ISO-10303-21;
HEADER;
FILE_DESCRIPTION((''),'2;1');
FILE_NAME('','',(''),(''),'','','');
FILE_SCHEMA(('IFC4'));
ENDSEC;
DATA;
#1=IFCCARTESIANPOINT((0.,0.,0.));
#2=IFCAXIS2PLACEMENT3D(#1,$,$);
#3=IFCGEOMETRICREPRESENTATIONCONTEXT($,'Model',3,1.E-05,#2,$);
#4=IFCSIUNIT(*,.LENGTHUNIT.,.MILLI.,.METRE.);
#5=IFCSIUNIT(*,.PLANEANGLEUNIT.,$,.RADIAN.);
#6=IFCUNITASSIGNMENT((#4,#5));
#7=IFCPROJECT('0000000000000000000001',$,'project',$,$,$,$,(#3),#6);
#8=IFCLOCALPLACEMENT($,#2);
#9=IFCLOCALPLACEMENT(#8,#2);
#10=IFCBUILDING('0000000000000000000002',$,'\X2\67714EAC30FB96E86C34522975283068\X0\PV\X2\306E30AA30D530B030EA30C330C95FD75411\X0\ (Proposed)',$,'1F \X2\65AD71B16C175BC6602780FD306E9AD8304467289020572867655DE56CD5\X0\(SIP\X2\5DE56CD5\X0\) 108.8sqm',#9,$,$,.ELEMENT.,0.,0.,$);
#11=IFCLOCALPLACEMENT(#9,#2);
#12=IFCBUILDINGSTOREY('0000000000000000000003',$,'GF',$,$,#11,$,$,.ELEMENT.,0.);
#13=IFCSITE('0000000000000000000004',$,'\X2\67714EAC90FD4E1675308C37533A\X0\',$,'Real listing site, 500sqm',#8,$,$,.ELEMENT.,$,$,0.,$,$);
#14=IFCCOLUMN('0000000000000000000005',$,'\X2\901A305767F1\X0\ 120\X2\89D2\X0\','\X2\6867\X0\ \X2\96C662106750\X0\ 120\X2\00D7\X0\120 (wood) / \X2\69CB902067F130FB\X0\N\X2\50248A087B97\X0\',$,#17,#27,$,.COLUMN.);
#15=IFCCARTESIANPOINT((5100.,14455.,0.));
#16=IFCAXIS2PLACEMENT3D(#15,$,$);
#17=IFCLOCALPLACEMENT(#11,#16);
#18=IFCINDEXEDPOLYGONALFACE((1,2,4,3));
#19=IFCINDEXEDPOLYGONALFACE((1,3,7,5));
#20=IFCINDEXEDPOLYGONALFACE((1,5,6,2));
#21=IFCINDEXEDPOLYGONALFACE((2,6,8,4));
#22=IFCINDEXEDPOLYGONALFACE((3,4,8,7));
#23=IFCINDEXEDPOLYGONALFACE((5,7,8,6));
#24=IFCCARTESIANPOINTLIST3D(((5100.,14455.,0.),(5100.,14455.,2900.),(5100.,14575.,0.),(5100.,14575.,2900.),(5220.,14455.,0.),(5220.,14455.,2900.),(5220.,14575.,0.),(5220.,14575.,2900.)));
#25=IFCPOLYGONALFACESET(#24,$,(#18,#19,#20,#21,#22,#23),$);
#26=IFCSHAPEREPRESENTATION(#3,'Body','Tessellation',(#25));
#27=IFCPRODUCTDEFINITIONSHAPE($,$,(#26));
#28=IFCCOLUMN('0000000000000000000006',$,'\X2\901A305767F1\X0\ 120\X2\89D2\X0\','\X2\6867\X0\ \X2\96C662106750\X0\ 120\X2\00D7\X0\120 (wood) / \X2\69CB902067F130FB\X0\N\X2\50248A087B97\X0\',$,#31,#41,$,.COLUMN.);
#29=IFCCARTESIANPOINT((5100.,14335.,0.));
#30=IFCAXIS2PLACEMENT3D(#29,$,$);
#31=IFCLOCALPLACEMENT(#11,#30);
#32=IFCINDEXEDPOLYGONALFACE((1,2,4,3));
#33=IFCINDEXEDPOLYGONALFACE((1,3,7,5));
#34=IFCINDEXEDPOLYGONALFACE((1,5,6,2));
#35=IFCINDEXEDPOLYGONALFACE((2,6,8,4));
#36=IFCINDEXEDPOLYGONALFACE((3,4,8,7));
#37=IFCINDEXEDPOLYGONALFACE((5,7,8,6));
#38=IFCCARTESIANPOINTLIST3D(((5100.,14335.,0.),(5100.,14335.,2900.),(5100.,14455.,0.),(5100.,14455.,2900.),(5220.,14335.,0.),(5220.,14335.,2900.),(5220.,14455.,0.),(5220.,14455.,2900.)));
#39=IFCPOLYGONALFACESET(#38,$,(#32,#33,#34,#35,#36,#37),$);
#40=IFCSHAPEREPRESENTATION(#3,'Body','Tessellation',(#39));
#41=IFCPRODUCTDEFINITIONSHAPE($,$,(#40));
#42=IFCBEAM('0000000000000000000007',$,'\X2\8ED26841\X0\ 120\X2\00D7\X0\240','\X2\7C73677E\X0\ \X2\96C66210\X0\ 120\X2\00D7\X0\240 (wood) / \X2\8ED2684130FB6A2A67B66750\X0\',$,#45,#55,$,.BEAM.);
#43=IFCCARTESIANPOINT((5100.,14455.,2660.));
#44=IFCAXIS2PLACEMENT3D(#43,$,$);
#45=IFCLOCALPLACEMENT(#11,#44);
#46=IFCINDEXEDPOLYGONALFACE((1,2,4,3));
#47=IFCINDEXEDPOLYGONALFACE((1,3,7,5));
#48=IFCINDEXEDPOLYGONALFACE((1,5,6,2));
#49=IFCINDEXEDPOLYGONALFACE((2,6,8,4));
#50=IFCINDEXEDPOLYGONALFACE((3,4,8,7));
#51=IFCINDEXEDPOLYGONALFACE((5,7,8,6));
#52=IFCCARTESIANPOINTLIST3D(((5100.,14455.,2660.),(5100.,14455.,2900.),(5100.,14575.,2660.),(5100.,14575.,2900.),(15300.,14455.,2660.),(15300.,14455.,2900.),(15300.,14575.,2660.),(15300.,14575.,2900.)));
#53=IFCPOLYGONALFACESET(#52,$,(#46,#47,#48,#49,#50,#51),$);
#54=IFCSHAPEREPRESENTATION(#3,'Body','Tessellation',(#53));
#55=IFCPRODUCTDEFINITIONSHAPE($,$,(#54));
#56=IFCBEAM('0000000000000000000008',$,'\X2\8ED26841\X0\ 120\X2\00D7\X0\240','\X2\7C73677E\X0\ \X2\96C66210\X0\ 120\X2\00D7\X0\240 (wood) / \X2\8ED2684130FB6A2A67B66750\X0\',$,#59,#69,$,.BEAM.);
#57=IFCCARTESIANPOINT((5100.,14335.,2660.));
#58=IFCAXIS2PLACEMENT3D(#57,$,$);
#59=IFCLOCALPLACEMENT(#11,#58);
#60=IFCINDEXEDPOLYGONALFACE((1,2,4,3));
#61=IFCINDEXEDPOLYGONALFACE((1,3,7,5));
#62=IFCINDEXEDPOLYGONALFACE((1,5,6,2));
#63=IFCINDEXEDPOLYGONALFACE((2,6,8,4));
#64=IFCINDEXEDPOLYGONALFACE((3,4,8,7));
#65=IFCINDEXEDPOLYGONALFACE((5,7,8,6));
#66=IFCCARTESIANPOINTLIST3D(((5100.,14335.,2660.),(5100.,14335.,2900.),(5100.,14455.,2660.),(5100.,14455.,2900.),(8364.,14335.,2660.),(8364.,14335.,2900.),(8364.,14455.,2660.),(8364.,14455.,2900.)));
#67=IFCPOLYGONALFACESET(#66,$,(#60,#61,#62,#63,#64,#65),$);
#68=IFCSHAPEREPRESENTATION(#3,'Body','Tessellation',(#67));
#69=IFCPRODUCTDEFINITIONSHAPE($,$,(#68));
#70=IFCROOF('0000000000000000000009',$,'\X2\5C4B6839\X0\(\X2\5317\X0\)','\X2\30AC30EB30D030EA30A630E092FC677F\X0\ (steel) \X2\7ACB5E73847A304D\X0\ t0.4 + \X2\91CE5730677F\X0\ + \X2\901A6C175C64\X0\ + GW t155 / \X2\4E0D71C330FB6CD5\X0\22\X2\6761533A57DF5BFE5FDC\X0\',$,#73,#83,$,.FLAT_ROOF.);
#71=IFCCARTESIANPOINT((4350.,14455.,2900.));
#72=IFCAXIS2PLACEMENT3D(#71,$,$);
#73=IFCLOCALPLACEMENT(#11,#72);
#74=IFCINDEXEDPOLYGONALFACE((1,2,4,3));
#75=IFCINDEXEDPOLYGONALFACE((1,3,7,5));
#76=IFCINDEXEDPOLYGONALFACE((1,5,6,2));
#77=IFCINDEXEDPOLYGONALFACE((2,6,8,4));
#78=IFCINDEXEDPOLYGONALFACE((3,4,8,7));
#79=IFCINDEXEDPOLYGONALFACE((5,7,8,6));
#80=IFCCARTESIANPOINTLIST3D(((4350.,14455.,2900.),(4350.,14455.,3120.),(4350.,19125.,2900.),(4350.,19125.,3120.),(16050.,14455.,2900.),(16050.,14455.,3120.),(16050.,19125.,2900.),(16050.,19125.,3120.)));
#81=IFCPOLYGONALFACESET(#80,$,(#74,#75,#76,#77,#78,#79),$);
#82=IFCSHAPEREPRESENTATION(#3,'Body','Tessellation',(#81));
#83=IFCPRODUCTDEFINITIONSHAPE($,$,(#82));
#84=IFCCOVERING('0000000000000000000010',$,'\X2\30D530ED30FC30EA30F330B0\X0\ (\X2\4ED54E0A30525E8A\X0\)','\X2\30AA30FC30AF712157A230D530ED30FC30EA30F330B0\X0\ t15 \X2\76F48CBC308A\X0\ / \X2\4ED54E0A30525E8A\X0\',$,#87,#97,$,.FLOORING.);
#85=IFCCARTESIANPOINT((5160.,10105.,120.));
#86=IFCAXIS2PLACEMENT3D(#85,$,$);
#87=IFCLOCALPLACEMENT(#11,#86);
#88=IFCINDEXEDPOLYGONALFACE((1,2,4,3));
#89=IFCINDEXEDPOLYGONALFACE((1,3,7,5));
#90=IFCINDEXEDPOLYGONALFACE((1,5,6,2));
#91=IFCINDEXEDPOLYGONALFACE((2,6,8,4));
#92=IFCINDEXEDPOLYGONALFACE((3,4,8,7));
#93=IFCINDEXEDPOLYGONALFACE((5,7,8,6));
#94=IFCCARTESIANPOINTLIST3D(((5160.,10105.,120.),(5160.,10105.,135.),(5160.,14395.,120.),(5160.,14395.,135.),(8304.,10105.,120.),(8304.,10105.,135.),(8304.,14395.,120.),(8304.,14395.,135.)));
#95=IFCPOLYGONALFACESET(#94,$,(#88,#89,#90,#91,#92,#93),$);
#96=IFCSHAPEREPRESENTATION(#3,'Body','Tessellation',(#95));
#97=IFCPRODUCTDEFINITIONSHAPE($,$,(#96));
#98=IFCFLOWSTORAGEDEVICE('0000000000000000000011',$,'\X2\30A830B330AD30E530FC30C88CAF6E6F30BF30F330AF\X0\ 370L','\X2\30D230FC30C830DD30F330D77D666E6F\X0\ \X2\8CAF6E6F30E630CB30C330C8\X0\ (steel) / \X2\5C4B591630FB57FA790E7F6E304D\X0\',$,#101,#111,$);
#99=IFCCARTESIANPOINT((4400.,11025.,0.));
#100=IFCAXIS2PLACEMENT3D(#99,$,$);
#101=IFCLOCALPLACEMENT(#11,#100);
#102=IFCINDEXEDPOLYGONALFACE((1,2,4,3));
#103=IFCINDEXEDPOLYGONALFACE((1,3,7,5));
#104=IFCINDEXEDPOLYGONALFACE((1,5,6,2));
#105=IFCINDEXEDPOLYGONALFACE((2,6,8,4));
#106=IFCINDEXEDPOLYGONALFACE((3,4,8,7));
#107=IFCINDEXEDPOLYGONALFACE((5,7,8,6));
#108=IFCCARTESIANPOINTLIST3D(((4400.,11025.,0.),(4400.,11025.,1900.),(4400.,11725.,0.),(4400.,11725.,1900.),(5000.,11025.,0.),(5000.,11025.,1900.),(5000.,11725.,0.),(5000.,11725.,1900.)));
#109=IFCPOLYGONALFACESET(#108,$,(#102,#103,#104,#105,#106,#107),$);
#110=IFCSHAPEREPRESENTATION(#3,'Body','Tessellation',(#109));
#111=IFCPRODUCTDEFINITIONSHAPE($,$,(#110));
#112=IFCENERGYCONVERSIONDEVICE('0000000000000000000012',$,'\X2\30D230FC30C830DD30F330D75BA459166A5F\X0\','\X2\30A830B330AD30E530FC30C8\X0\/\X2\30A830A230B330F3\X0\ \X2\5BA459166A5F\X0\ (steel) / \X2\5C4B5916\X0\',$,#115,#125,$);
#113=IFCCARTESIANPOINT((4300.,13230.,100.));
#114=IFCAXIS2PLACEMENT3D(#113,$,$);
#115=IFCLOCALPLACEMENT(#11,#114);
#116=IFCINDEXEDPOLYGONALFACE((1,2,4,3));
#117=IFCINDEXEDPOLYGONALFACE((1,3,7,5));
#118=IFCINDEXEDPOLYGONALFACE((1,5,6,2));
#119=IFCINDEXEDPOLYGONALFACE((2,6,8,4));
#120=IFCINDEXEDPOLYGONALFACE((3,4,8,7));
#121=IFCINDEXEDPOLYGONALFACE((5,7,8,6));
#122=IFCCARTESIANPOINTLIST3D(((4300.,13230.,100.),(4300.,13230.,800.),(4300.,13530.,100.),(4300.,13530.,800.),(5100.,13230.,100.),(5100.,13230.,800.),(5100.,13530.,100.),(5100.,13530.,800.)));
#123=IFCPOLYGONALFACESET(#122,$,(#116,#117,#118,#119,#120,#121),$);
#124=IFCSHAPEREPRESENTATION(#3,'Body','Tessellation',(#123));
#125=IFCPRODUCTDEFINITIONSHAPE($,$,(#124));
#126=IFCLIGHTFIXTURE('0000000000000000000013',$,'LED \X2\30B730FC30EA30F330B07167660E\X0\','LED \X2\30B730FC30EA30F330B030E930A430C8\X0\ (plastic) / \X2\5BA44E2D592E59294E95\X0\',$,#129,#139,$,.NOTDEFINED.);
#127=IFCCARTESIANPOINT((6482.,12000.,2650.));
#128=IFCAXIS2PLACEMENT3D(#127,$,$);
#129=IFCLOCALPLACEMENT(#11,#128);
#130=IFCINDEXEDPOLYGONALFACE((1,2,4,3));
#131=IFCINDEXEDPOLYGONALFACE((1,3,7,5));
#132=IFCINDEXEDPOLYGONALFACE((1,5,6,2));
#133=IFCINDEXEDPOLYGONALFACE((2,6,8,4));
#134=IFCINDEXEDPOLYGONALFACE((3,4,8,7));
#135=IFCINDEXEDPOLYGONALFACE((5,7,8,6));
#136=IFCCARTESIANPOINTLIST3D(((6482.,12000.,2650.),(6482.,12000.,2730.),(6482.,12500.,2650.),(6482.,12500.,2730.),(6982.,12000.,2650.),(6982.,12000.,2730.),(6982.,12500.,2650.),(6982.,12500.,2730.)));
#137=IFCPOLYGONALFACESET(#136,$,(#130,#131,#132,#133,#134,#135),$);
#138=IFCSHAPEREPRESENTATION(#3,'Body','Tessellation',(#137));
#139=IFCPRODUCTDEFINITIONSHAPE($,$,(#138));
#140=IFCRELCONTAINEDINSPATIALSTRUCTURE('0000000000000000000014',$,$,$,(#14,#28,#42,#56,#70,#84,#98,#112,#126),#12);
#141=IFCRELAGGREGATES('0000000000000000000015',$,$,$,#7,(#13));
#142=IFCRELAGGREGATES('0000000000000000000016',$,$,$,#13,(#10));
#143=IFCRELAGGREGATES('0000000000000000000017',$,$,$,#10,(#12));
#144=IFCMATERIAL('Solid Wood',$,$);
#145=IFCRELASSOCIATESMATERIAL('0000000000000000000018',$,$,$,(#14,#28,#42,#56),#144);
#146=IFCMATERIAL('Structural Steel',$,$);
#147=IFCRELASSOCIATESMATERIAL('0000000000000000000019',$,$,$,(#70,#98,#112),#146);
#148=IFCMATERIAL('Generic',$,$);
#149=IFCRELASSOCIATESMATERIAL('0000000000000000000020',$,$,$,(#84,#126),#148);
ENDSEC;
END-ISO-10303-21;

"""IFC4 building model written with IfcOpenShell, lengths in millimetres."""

from ifc_helpers import new_model, si_unit, frame, frame_2d, origin, place, context, project, spatial, rectangle, extrude, material, element, save


model = new_model("IFC4")

# Units and contexts
model_context = context("Model", 3, precision=1e-05, world=origin())
ifc_project = project(units=[si_unit("LENGTHUNIT", "METRE", prefix="MILLI"), si_unit("PLANEANGLEUNIT", "RADIAN")], contexts=[model_context])

# Site, building, storey
site_placement = place(None, origin())
site = spatial("IfcSite", under=ifc_project, at=site_placement, Name="東京都世田谷区", ObjectType="Real listing site, 500sqm", CompositionType="ELEMENT", RefElevation=0.0)
building_placement = place(site_placement, origin())
building = spatial("IfcBuilding", under=site, at=building_placement, Name="東京・雨水利用とPVのオフグリッド志向 (Proposed)", ObjectType="1F 断熱気密性能の高い木造在来工法(SIP工法) 108.8sqm", CompositionType="ELEMENT", ElevationOfRefHeight=0.0, ElevationOfTerrain=0.0)
storey_placement = place(building_placement, origin())
storey = spatial("IfcBuildingStorey", under=building, at=storey_placement, Name="GF", CompositionType="ELEMENT", Elevation=0.0)

# Columns
ifc_material_1 = material(Name="Solid Wood")
column_1_placement = place(storey_placement, frame((5100.0, 14455.0, 0.0)))
element("IfcColumn", 1, at=column_1_placement, inside=storey, material=ifc_material_1, Name="通し柱 120角", Description="桧 集成材 120×120 (wood) / 構造柱・N値計算", PredefinedType="COLUMN", context=model_context, shape_type="SweptSolid", body=[
    extrude(rectangle(XDim=120.0, YDim=120.0, at=frame_2d((60.0, 60.0))), frame((5100.0, 14455.0, 0.0)), (0.0, 0.0, 1.0), 2900.0),
])
column_2_placement = place(storey_placement, frame((5100.0, 14335.0, 0.0)))
element("IfcColumn", 2, at=column_2_placement, inside=storey, material=ifc_material_1, Name="通し柱 120角", Description="桧 集成材 120×120 (wood) / 構造柱・N値計算", PredefinedType="COLUMN", context=model_context, shape_type="SweptSolid", body=[
    extrude(rectangle(XDim=120.0, YDim=120.0, at=frame_2d((60.0, 60.0))), frame((5100.0, 14335.0, 0.0)), (0.0, 0.0, 1.0), 2900.0),
])

# Beams
beam_1_placement = place(storey_placement, frame((5100.0, 14455.0, 2660.0)))
element("IfcBeam", 3, at=beam_1_placement, inside=storey, material=ifc_material_1, Name="軒桁 120×240", Description="米松 集成 120×240 (wood) / 軒桁・横架材", PredefinedType="BEAM", context=model_context, shape_type="SweptSolid", body=[
    extrude(rectangle(XDim=10200.0, YDim=120.0, at=frame_2d((5100.0, 60.0))), frame((5100.0, 14455.0, 2660.0)), (0.0, 0.0, 1.0), 240.0),
])
beam_2_placement = place(storey_placement, frame((5100.0, 14335.0, 2660.0)))
element("IfcBeam", 4, at=beam_2_placement, inside=storey, material=ifc_material_1, Name="軒桁 120×240", Description="米松 集成 120×240 (wood) / 軒桁・横架材", PredefinedType="BEAM", context=model_context, shape_type="SweptSolid", body=[
    extrude(rectangle(XDim=3264.0, YDim=120.0, at=frame_2d((1632.0, 60.0))), frame((5100.0, 14335.0, 2660.0)), (0.0, 0.0, 1.0), 240.0),
])

# Roof
ifc_material_2 = material(Name="Structural Steel")
roof_placement = place(storey_placement, frame((4350.0, 14455.0, 2900.0)))
element("IfcRoof", 5, at=roof_placement, inside=storey, material=ifc_material_2, Name="屋根(北)", Description="ガルバリウム鋼板 (steel) 立平葺き t0.4 + 野地板 + 通気層 + GW t155 / 不燃・法22条区域対応", PredefinedType="FLAT_ROOF", context=model_context, shape_type="SweptSolid", body=[
    extrude(rectangle(XDim=11700.0, YDim=4670.0, at=frame_2d((5850.0, 2335.0))), frame((4350.0, 14455.0, 2900.0)), (0.0, 0.0, 1.0), 220.0),
])

# Covering
ifc_material_3 = material(Name="Generic")
covering_placement = place(storey_placement, frame((5160.0, 10105.0, 120.0)))
element("IfcCovering", 6, at=covering_placement, inside=storey, material=ifc_material_3, Name="フローリング (仕上げ床)", Description="オーク無垢フローリング t15 直貼り / 仕上げ床", PredefinedType="FLOORING", context=model_context, shape_type="SweptSolid", body=[
    extrude(rectangle(XDim=3144.0, YDim=4290.0, at=frame_2d((1572.0, 2145.0))), frame((5160.0, 10105.0, 120.0)), (0.0, 0.0, 1.0), 15.0),
])

# Flow storage device
flow_storage_device_placement = place(storey_placement, frame((4400.0, 11025.0, 0.0)))
element("IfcFlowStorageDevice", 7, at=flow_storage_device_placement, inside=storey, material=ifc_material_2, Name="エコキュート貯湯タンク 370L", Description="ヒートポンプ給湯 貯湯ユニット (steel) / 屋外・基礎置き", context=model_context, shape_type="SweptSolid", body=[
    extrude(rectangle(XDim=600.0, YDim=700.0, at=frame_2d((300.0, 350.0))), frame((4400.0, 11025.0, 0.0)), (0.0, 0.0, 1.0), 1900.0),
])

# Energy conversion device
energy_conversion_device_placement = place(storey_placement, frame((4300.0, 13230.0, 100.0)))
element("IfcEnergyConversionDevice", 8, at=energy_conversion_device_placement, inside=storey, material=ifc_material_2, Name="ヒートポンプ室外機", Description="エコキュート/エアコン 室外機 (steel) / 屋外", context=model_context, shape_type="SweptSolid", body=[
    extrude(rectangle(XDim=800.0, YDim=300.0, at=frame_2d((400.0, 150.0))), frame((4300.0, 13230.0, 100.0)), (0.0, 0.0, 1.0), 700.0),
])

# Light fixture
light_fixture_placement = place(storey_placement, frame((6482.0, 12000.0, 2650.0)))
element("IfcLightFixture", 9, at=light_fixture_placement, inside=storey, material=ifc_material_3, Name="LED シーリング照明", Description="LED シーリングライト (plastic) / 室中央天井", PredefinedType="NOTDEFINED", context=model_context, shape_type="SweptSolid", body=[
    extrude(rectangle(XDim=500.0, YDim=500.0, at=frame_2d((250.0, 250.0))), frame((6482.0, 12000.0, 2650.0)), (0.0, 0.0, 1.0), 80.0),
])

save(model, "model.ifc")
